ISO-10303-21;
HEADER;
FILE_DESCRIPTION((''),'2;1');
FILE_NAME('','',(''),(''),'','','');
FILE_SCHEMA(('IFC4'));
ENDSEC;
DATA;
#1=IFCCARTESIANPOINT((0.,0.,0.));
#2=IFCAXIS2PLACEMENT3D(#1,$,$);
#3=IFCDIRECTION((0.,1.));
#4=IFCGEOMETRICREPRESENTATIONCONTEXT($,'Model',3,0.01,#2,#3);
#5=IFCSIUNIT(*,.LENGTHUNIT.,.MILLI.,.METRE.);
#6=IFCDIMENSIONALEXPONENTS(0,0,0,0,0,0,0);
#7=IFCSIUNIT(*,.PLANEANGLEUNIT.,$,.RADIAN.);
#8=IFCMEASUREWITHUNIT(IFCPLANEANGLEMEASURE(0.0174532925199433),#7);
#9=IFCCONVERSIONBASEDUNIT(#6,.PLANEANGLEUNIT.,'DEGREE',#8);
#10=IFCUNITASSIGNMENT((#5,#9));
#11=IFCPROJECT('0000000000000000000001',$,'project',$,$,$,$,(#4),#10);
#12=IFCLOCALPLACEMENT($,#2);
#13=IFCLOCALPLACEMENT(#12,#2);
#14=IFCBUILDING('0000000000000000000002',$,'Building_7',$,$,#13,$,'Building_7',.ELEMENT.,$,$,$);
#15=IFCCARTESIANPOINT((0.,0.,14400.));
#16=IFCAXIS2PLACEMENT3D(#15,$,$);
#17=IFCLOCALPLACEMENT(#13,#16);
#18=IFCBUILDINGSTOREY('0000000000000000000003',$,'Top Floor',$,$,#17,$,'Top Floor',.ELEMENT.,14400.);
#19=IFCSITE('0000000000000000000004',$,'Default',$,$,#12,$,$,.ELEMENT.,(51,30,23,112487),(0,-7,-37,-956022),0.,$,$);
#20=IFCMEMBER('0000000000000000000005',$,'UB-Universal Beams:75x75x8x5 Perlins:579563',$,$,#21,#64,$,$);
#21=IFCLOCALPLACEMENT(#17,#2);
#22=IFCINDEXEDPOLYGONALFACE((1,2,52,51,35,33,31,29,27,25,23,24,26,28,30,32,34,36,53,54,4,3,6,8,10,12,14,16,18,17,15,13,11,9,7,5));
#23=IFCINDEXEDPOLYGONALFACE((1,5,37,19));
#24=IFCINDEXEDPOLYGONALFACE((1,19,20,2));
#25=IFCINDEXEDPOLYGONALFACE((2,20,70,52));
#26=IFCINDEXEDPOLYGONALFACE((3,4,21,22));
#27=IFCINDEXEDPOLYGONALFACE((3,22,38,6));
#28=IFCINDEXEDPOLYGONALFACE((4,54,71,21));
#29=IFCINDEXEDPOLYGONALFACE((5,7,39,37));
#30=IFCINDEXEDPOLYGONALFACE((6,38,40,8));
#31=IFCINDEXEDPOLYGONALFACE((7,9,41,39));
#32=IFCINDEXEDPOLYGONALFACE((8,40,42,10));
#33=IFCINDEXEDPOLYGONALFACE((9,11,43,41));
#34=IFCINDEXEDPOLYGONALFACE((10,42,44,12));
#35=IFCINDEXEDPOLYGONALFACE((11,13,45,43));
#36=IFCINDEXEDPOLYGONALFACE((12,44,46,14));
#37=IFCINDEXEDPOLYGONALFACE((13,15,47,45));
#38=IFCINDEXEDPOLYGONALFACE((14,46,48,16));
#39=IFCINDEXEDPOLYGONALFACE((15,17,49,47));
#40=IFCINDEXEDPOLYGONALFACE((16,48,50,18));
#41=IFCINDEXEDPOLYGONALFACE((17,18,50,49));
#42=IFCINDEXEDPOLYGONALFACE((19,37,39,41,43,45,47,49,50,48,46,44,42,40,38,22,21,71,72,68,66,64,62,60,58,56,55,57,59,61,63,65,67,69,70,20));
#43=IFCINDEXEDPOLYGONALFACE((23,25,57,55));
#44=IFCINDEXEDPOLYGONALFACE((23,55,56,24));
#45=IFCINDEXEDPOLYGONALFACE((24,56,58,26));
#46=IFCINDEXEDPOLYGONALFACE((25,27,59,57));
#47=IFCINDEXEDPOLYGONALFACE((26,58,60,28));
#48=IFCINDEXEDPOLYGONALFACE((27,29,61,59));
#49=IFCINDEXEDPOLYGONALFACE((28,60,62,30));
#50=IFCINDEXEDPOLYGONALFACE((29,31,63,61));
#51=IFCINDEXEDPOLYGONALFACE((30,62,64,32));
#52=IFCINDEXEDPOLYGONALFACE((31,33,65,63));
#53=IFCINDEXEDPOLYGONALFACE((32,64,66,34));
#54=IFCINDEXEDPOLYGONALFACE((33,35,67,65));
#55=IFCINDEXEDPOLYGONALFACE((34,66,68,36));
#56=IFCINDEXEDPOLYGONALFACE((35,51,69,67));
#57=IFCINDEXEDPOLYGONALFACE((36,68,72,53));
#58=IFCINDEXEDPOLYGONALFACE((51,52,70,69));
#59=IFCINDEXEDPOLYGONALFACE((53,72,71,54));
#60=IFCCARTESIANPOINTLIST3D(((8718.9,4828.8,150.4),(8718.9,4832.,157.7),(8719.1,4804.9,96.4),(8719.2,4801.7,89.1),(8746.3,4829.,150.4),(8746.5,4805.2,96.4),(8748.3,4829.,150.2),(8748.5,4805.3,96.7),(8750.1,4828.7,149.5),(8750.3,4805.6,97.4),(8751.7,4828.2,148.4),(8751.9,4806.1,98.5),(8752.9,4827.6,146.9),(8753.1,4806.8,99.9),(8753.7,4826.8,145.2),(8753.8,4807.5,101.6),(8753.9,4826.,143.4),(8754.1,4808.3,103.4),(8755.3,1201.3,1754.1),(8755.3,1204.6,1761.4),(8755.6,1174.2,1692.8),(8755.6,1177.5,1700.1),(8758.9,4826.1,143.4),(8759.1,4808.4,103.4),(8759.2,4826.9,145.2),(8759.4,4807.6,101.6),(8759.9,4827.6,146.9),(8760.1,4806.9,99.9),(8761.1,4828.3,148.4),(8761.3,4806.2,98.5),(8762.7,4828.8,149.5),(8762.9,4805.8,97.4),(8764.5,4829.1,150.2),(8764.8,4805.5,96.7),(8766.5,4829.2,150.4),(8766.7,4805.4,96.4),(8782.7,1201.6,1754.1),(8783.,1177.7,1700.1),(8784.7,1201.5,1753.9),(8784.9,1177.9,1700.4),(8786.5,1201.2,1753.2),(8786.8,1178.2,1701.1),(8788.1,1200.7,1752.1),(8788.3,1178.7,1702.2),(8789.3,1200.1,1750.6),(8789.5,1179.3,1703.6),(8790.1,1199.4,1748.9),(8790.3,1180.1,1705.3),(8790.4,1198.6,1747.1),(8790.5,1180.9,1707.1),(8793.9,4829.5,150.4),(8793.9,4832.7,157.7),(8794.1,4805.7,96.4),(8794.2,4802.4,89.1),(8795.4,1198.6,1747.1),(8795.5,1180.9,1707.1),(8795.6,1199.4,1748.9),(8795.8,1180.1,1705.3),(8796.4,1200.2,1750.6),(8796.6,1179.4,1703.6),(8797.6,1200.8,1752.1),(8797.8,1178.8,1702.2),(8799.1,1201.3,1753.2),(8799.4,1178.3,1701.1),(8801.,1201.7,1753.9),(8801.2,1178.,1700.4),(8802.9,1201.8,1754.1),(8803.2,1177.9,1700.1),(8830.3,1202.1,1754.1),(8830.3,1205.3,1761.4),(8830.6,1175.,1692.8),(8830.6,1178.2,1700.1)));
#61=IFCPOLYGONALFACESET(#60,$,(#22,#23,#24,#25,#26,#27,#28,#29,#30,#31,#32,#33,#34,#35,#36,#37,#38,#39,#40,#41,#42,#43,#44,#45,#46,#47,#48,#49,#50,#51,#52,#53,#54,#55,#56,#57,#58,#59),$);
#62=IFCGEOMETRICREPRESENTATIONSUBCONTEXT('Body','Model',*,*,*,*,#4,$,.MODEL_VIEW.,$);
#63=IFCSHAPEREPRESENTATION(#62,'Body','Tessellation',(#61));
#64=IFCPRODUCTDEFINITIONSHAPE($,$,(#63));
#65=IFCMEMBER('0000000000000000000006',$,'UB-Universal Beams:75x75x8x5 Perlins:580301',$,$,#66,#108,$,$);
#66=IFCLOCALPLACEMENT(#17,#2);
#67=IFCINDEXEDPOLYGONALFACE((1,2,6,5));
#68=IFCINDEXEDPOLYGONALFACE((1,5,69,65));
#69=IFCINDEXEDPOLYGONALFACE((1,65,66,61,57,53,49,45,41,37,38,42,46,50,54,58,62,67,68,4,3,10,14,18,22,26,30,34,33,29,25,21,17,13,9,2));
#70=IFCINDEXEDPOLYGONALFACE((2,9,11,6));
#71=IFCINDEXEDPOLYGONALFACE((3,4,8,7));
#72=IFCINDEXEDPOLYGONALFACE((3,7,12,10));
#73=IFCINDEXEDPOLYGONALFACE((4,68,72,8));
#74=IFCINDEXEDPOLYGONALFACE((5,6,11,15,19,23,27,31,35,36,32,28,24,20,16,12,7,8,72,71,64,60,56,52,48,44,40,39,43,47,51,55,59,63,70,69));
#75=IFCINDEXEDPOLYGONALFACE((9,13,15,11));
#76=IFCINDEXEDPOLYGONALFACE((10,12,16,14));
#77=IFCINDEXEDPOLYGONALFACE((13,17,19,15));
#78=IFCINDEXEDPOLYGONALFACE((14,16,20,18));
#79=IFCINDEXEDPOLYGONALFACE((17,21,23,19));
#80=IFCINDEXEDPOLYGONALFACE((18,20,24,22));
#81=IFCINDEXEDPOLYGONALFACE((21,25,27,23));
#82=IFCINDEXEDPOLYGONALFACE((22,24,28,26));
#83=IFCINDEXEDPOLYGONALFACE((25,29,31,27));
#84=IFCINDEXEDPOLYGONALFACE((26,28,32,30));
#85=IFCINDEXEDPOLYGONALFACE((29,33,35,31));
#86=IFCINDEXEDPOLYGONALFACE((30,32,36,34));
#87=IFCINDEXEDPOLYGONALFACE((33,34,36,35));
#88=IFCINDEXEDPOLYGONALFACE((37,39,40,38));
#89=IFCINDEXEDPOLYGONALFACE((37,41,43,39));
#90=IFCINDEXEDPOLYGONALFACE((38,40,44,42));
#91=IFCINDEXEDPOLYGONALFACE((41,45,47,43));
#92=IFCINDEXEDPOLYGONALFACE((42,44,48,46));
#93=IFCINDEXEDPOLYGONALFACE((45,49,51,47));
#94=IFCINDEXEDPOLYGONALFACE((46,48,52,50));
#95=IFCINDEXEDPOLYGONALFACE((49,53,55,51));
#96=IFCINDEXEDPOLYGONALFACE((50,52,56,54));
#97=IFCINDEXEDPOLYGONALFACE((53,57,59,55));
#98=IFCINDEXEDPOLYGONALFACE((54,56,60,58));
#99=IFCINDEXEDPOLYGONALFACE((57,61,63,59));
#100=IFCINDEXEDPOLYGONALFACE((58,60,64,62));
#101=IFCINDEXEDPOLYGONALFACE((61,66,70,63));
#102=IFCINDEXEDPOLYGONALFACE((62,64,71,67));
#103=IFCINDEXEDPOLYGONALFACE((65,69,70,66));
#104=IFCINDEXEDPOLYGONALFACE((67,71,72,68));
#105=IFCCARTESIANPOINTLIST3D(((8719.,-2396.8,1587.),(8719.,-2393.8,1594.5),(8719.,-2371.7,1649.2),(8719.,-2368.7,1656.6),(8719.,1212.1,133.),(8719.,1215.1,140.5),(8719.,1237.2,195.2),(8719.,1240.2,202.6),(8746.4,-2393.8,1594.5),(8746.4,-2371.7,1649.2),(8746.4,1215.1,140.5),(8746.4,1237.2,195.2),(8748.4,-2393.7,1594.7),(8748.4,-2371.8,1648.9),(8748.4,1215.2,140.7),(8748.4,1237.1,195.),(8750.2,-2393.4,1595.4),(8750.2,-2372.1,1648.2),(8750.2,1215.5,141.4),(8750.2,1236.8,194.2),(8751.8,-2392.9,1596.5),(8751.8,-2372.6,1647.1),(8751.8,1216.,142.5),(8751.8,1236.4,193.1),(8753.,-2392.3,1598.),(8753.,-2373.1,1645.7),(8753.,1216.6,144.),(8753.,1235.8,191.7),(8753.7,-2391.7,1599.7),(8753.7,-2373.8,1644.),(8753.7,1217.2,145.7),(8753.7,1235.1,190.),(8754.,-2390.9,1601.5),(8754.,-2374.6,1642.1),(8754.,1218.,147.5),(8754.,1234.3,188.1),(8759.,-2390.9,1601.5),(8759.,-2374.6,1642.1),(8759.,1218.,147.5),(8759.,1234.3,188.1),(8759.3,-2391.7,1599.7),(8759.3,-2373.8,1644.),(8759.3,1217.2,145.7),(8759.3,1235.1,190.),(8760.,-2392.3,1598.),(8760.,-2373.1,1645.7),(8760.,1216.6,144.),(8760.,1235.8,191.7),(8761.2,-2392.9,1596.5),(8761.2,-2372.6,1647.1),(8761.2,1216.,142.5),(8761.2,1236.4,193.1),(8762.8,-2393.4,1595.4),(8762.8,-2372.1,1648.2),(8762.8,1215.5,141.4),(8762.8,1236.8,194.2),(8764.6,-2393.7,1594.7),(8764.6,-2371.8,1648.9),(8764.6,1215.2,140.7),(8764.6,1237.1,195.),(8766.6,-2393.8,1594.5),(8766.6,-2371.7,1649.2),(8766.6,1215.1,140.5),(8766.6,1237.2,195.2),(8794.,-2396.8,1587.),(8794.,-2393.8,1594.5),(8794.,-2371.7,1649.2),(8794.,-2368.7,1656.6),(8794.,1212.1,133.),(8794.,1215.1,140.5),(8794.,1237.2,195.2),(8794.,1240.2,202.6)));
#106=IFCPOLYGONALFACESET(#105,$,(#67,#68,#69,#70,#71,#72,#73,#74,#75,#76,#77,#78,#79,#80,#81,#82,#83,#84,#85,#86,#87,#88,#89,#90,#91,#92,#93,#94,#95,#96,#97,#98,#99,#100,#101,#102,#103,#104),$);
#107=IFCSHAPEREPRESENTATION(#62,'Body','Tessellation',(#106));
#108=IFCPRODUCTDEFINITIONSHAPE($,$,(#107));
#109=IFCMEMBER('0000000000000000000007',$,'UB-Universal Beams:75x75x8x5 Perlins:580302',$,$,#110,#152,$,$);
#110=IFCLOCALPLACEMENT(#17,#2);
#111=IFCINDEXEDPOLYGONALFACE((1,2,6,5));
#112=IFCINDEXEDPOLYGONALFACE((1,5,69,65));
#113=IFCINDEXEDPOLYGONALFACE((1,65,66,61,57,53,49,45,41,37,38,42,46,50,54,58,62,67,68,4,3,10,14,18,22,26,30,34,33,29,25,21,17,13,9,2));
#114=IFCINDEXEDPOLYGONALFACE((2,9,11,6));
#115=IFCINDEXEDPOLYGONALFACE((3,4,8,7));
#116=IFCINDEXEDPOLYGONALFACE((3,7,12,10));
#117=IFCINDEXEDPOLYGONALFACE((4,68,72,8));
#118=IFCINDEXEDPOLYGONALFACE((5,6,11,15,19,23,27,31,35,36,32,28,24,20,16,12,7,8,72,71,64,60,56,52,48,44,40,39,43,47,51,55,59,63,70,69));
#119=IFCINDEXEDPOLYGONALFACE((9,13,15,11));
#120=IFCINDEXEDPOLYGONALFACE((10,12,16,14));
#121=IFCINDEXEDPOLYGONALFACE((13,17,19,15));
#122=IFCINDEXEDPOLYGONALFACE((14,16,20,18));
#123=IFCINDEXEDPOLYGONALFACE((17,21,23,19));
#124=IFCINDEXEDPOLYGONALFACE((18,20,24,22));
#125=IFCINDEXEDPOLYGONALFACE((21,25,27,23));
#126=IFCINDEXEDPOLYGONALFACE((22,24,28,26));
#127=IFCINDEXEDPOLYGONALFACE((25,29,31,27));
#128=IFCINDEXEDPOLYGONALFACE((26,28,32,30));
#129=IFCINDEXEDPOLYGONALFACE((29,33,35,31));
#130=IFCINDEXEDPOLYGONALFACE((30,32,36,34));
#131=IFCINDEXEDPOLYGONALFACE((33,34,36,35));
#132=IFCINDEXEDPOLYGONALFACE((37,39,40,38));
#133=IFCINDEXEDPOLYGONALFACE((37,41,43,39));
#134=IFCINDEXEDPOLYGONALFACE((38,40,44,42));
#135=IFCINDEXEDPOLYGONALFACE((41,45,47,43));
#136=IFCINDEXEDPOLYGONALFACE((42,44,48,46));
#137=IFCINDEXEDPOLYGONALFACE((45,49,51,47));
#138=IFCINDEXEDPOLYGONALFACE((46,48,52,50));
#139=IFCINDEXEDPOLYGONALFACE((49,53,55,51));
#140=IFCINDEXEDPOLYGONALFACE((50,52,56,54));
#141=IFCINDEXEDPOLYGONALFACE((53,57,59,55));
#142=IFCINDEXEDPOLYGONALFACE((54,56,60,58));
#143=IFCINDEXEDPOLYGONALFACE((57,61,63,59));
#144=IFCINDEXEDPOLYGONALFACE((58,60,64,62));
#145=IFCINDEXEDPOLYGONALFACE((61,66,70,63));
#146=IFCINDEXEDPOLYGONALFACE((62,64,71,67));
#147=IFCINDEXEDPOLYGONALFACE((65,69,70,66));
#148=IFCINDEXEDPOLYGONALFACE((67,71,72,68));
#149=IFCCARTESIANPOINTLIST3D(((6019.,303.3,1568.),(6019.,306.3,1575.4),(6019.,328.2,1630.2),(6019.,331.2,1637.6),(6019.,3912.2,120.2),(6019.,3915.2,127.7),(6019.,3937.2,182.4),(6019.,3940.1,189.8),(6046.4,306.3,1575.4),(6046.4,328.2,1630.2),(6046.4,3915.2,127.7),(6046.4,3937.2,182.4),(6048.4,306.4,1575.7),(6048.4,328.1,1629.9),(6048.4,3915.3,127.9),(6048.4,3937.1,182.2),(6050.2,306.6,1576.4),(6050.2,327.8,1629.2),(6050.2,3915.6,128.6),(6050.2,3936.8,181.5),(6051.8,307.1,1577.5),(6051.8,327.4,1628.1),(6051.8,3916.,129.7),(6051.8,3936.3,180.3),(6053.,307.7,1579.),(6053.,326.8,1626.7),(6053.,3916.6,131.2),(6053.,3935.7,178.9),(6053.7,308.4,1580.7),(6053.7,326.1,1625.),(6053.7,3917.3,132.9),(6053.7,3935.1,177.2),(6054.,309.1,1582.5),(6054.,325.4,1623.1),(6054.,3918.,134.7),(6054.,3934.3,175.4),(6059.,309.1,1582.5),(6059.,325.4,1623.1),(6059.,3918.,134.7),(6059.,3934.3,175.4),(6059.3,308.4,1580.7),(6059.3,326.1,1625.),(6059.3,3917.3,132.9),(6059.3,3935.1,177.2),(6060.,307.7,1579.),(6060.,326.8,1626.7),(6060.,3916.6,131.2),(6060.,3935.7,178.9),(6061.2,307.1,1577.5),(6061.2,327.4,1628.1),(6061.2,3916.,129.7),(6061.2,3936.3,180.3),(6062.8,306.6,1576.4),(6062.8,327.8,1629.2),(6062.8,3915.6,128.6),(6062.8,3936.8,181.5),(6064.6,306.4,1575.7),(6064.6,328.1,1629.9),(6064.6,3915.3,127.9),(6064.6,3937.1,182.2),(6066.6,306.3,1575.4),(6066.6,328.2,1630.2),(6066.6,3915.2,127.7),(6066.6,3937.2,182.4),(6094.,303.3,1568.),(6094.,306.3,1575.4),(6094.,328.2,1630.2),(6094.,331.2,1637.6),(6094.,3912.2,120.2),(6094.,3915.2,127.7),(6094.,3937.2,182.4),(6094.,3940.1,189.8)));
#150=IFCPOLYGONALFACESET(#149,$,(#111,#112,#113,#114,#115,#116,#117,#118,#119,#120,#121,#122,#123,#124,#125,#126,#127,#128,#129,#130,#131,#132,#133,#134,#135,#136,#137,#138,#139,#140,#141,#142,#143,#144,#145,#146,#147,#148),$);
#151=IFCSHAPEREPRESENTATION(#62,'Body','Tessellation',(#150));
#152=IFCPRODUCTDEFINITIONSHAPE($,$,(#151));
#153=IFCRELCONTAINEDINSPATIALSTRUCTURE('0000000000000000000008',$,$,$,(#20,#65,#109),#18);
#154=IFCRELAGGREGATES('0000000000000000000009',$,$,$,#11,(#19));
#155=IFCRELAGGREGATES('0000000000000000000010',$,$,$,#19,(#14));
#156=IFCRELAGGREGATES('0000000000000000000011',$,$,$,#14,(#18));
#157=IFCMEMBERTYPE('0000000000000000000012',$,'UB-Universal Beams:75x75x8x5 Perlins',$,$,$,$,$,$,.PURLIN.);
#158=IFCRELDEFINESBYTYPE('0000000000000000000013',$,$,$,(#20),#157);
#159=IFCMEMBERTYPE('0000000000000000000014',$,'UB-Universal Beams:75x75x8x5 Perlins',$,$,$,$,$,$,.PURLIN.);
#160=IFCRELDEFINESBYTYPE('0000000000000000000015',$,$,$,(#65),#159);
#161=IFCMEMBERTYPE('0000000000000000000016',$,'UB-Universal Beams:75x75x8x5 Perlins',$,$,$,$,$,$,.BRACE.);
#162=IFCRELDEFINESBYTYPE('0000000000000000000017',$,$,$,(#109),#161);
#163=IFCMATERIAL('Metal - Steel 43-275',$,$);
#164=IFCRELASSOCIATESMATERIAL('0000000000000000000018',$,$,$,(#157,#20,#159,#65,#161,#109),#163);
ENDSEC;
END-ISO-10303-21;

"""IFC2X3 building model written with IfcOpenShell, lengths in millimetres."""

from ifc_helpers import new_model, entity, si_unit, converted_unit, direction, frame, frame_2d, origin, place, context, subcontext, project, spatial, polyline, circle_curve, parameter, trimmed, segment, composite_curve, outline, extrude, source, transform, mapped, material, type_object, type_shapes, element, save


model = new_model("IFC2X3")

# Units and contexts
model_context = context("Model", 3, precision=0.01, world=origin(), true_north=direction((0.0, 1.0)))
body_context = subcontext(model_context, "Body", "Model", "MODEL_VIEW")
ifc_project = project(units=[si_unit("LENGTHUNIT", "METRE", prefix="MILLI"), converted_unit("PLANEANGLEUNIT", "DEGREE", entity("IfcPlaneAngleMeasure", 0.0174532925199433), si_unit("PLANEANGLEUNIT", "RADIAN"), dimensions=[0, 0, 0, 0, 0, 0, 0])], contexts=[model_context])

# Site, building, storey
site_placement = place(None, origin())
site = spatial("IfcSite", under=ifc_project, at=site_placement, Name="Default", CompositionType="ELEMENT", RefLatitude=(51, 30, 23, 112487), RefLongitude=(0, -7, -37, -956022), RefElevation=0.0)
building_placement = place(site_placement, origin())
building = spatial("IfcBuilding", under=site, at=building_placement, Name="Building_7", LongName="Building_7", CompositionType="ELEMENT")
storey_placement = place(building_placement, frame((0.0, 0.0, 14400.0)))
storey = spatial("IfcBuildingStorey", under=building, at=storey_placement, Name="Top Floor", LongName="Top Floor", CompositionType="ELEMENT", Elevation=14400.0)

# Shared definitions
ifc_material = material(Name="Metal - Steel 43-275")

# Members
member_type_1 = type_object("IfcMemberType", Name="UB-Universal Beams:75x75x8x5 Perlins", PredefinedType="PURLIN", material=ifc_material)
shared_shape_1 = source(origin(), body_context, "Body", "SweptSolid", [
    extrude(outline(composite_curve([segment(polyline([(29.5, -37.5), (37.5, -37.5)]), True, "CONTINUOUS"), segment(polyline([(37.5, -37.5), (37.5, 37.5)]), True, "CONTINUOUS"), segment(polyline([(37.5, 37.5), (29.5, 37.5)]), True, "CONTINUOUS"), segment(polyline([(29.5, 37.5), (29.5, 10.1)]), True, "CONTINUOUS"), segment(trimmed(circle_curve(frame_2d((21.9, 10.1), x_axis=(0.0, 1.0)), 7.6), [parameter(180.0)], [parameter(270.0)], True, "PARAMETER"), False, "CONTINUOUS"), segment(polyline([(21.9, 2.5), (-21.9, 2.5)]), True, "CONTINUOUS"), segment(trimmed(circle_curve(frame_2d((-21.9, 10.1), x_axis=(0.0, 1.0)), 7.6), [parameter(90.0)], [parameter(180.0)], True, "PARAMETER"), False, "CONTINUOUS"), segment(polyline([(-29.5, 10.1), (-29.5, 37.5)]), True, "CONTINUOUS"), segment(polyline([(-29.5, 37.5), (-37.5, 37.5)]), True, "CONTINUOUS"), segment(polyline([(-37.5, 37.5), (-37.5, -37.5)]), True, "CONTINUOUS"), segment(polyline([(-37.5, -37.5), (-29.5, -37.5)]), True, "CONTINUOUS"), segment(polyline([(-29.5, -37.5), (-29.5, -10.1)]), True, "CONTINUOUS"), segment(trimmed(circle_curve(frame_2d((-21.9, -10.1), x_axis=(0.0, 1.0)), 7.6), [parameter(360.0)], [parameter(90.0)], True, "PARAMETER"), False, "CONTINUOUS"), segment(polyline([(-21.9, -2.5), (21.9, -2.5)]), True, "CONTINUOUS"), segment(trimmed(circle_curve(frame_2d((21.9, -10.1), x_axis=(0.0, 1.0)), 7.6), [parameter(270.0)], [parameter(360.0)], True, "PARAMETER"), False, "CONTINUOUS"), segment(polyline([(29.5, -10.1), (29.5, -37.5)]), True, "CONTINUOUS")], self_intersect=False)), frame((-1983.2, 0.0, 0.0), z_axis=(1.0, 0.0, 0.0), x_axis=(0.0, 0.0, -1.0)), (0.0, 0.0, 1.0), 3966.3),
])
type_shapes(member_type_1, [shared_shape_1])
member_1_placement = place(storey_placement, frame((8774.7, 3003.5, 925.3), z_axis=(-0.004061, 0.404312, 0.914612), x_axis=(0.009187, -0.914566, 0.404332)))
element("IfcMember", 1, at=member_1_placement, inside=storey, type_object=member_type_1, material=ifc_material, Name="UB-Universal Beams:75x75x8x5 Perlins:579563", context=body_context, shape_type="MappedRepresentation", body=[
    mapped(shared_shape_1, transform((0.0, 0.0, 0.0), scale=1.0)),
])
member_type_2 = type_object("IfcMemberType", Name="UB-Universal Beams:75x75x8x5 Perlins", PredefinedType="PURLIN", material=ifc_material)
shared_shape_2 = source(origin(), body_context, "Body", "SweptSolid", [
    extrude(outline(composite_curve([segment(polyline([(29.5, -37.5), (37.5, -37.5)]), True, "CONTINUOUS"), segment(polyline([(37.5, -37.5), (37.5, 37.5)]), True, "CONTINUOUS"), segment(polyline([(37.5, 37.5), (29.5, 37.5)]), True, "CONTINUOUS"), segment(polyline([(29.5, 37.5), (29.5, 10.1)]), True, "CONTINUOUS"), segment(trimmed(circle_curve(frame_2d((21.9, 10.1), x_axis=(0.0, 1.0)), 7.6), [parameter(180.0)], [parameter(270.0)], True, "PARAMETER"), False, "CONTINUOUS"), segment(polyline([(21.9, 2.5), (-21.9, 2.5)]), True, "CONTINUOUS"), segment(trimmed(circle_curve(frame_2d((-21.9, 10.1), x_axis=(0.0, 1.0)), 7.6), [parameter(90.0)], [parameter(180.0)], True, "PARAMETER"), False, "CONTINUOUS"), segment(polyline([(-29.5, 10.1), (-29.5, 37.5)]), True, "CONTINUOUS"), segment(polyline([(-29.5, 37.5), (-37.5, 37.5)]), True, "CONTINUOUS"), segment(polyline([(-37.5, 37.5), (-37.5, -37.5)]), True, "CONTINUOUS"), segment(polyline([(-37.5, -37.5), (-29.5, -37.5)]), True, "CONTINUOUS"), segment(polyline([(-29.5, -37.5), (-29.5, -10.1)]), True, "CONTINUOUS"), segment(trimmed(circle_curve(frame_2d((-21.9, -10.1), x_axis=(0.0, 1.0)), 7.6), [parameter(360.0)], [parameter(90.0)], True, "PARAMETER"), False, "CONTINUOUS"), segment(polyline([(-21.9, -2.5), (21.9, -2.5)]), True, "CONTINUOUS"), segment(trimmed(circle_curve(frame_2d((21.9, -10.1), x_axis=(0.0, 1.0)), 7.6), [parameter(270.0)], [parameter(360.0)], True, "PARAMETER"), False, "CONTINUOUS"), segment(polyline([(29.5, -10.1), (29.5, -37.5)]), True, "CONTINUOUS")], self_intersect=False)), frame((-1945.4, 0.0, 0.0), z_axis=(1.0, 0.0, 0.0), x_axis=(0.0, 0.0, -1.0)), (0.0, 0.0, 1.0), 3890.8),
])
type_shapes(member_type_2, [shared_shape_2])
member_2_placement = place(storey_placement, frame((8756.5, -578.3, 894.8), z_axis=(0.0, 0.373701, 0.927549), x_axis=(0.0, 0.927549, -0.373701)))
element("IfcMember", 2, at=member_2_placement, inside=storey, type_object=member_type_2, material=ifc_material, Name="UB-Universal Beams:75x75x8x5 Perlins:580301", context=body_context, shape_type="MappedRepresentation", body=[
    mapped(shared_shape_2, transform((0.0, 0.0, 0.0), scale=1.0)),
])
member_type_3 = type_object("IfcMemberType", Name="UB-Universal Beams:75x75x8x5 Perlins", PredefinedType="BRACE", material=ifc_material)
shared_shape_3 = source(origin(), body_context, "Body", "SweptSolid", [
    extrude(outline(composite_curve([segment(polyline([(29.5, -37.5), (37.5, -37.5)]), True, "CONTINUOUS"), segment(polyline([(37.5, -37.5), (37.5, 37.5)]), True, "CONTINUOUS"), segment(polyline([(37.5, 37.5), (29.5, 37.5)]), True, "CONTINUOUS"), segment(polyline([(29.5, 37.5), (29.5, 10.1)]), True, "CONTINUOUS"), segment(trimmed(circle_curve(frame_2d((21.9, 10.1), x_axis=(0.0, 1.0)), 7.6), [parameter(180.0)], [parameter(270.0)], True, "PARAMETER"), False, "CONTINUOUS"), segment(polyline([(21.9, 2.5), (-21.9, 2.5)]), True, "CONTINUOUS"), segment(trimmed(circle_curve(frame_2d((-21.9, 10.1), x_axis=(0.0, 1.0)), 7.6), [parameter(90.0)], [parameter(180.0)], True, "PARAMETER"), False, "CONTINUOUS"), segment(polyline([(-29.5, 10.1), (-29.5, 37.5)]), True, "CONTINUOUS"), segment(polyline([(-29.5, 37.5), (-37.5, 37.5)]), True, "CONTINUOUS"), segment(polyline([(-37.5, 37.5), (-37.5, -37.5)]), True, "CONTINUOUS"), segment(polyline([(-37.5, -37.5), (-29.5, -37.5)]), True, "CONTINUOUS"), segment(polyline([(-29.5, -37.5), (-29.5, -10.1)]), True, "CONTINUOUS"), segment(trimmed(circle_curve(frame_2d((-21.9, -10.1), x_axis=(0.0, 1.0)), 7.6), [parameter(360.0)], [parameter(90.0)], True, "PARAMETER"), False, "CONTINUOUS"), segment(polyline([(-21.9, -2.5), (21.9, -2.5)]), True, "CONTINUOUS"), segment(trimmed(circle_curve(frame_2d((21.9, -10.1), x_axis=(0.0, 1.0)), 7.6), [parameter(270.0)], [parameter(360.0)], True, "PARAMETER"), False, "CONTINUOUS"), segment(polyline([(29.5, -10.1), (29.5, -37.5)]), True, "CONTINUOUS")], self_intersect=False)), frame((-1944.2, 0.0, 0.0), z_axis=(1.0, 0.0, 0.0), x_axis=(0.0, 0.0, -1.0)), (0.0, 0.0, 1.0), 3888.5),
])
type_shapes(member_type_3, [shared_shape_3])
member_3_placement = place(storey_placement, frame((6056.5, 2121.7, 878.9), z_axis=(0.0, 0.372323, 0.928103), x_axis=(0.0, -0.928103, 0.372323)))
element("IfcMember", 3, at=member_3_placement, inside=storey, type_object=member_type_3, material=ifc_material, Name="UB-Universal Beams:75x75x8x5 Perlins:580302", context=body_context, shape_type="MappedRepresentation", body=[
    mapped(shared_shape_3, transform((0.0, 0.0, 0.0), scale=1.0)),
])

save(model, "model.ifc")
